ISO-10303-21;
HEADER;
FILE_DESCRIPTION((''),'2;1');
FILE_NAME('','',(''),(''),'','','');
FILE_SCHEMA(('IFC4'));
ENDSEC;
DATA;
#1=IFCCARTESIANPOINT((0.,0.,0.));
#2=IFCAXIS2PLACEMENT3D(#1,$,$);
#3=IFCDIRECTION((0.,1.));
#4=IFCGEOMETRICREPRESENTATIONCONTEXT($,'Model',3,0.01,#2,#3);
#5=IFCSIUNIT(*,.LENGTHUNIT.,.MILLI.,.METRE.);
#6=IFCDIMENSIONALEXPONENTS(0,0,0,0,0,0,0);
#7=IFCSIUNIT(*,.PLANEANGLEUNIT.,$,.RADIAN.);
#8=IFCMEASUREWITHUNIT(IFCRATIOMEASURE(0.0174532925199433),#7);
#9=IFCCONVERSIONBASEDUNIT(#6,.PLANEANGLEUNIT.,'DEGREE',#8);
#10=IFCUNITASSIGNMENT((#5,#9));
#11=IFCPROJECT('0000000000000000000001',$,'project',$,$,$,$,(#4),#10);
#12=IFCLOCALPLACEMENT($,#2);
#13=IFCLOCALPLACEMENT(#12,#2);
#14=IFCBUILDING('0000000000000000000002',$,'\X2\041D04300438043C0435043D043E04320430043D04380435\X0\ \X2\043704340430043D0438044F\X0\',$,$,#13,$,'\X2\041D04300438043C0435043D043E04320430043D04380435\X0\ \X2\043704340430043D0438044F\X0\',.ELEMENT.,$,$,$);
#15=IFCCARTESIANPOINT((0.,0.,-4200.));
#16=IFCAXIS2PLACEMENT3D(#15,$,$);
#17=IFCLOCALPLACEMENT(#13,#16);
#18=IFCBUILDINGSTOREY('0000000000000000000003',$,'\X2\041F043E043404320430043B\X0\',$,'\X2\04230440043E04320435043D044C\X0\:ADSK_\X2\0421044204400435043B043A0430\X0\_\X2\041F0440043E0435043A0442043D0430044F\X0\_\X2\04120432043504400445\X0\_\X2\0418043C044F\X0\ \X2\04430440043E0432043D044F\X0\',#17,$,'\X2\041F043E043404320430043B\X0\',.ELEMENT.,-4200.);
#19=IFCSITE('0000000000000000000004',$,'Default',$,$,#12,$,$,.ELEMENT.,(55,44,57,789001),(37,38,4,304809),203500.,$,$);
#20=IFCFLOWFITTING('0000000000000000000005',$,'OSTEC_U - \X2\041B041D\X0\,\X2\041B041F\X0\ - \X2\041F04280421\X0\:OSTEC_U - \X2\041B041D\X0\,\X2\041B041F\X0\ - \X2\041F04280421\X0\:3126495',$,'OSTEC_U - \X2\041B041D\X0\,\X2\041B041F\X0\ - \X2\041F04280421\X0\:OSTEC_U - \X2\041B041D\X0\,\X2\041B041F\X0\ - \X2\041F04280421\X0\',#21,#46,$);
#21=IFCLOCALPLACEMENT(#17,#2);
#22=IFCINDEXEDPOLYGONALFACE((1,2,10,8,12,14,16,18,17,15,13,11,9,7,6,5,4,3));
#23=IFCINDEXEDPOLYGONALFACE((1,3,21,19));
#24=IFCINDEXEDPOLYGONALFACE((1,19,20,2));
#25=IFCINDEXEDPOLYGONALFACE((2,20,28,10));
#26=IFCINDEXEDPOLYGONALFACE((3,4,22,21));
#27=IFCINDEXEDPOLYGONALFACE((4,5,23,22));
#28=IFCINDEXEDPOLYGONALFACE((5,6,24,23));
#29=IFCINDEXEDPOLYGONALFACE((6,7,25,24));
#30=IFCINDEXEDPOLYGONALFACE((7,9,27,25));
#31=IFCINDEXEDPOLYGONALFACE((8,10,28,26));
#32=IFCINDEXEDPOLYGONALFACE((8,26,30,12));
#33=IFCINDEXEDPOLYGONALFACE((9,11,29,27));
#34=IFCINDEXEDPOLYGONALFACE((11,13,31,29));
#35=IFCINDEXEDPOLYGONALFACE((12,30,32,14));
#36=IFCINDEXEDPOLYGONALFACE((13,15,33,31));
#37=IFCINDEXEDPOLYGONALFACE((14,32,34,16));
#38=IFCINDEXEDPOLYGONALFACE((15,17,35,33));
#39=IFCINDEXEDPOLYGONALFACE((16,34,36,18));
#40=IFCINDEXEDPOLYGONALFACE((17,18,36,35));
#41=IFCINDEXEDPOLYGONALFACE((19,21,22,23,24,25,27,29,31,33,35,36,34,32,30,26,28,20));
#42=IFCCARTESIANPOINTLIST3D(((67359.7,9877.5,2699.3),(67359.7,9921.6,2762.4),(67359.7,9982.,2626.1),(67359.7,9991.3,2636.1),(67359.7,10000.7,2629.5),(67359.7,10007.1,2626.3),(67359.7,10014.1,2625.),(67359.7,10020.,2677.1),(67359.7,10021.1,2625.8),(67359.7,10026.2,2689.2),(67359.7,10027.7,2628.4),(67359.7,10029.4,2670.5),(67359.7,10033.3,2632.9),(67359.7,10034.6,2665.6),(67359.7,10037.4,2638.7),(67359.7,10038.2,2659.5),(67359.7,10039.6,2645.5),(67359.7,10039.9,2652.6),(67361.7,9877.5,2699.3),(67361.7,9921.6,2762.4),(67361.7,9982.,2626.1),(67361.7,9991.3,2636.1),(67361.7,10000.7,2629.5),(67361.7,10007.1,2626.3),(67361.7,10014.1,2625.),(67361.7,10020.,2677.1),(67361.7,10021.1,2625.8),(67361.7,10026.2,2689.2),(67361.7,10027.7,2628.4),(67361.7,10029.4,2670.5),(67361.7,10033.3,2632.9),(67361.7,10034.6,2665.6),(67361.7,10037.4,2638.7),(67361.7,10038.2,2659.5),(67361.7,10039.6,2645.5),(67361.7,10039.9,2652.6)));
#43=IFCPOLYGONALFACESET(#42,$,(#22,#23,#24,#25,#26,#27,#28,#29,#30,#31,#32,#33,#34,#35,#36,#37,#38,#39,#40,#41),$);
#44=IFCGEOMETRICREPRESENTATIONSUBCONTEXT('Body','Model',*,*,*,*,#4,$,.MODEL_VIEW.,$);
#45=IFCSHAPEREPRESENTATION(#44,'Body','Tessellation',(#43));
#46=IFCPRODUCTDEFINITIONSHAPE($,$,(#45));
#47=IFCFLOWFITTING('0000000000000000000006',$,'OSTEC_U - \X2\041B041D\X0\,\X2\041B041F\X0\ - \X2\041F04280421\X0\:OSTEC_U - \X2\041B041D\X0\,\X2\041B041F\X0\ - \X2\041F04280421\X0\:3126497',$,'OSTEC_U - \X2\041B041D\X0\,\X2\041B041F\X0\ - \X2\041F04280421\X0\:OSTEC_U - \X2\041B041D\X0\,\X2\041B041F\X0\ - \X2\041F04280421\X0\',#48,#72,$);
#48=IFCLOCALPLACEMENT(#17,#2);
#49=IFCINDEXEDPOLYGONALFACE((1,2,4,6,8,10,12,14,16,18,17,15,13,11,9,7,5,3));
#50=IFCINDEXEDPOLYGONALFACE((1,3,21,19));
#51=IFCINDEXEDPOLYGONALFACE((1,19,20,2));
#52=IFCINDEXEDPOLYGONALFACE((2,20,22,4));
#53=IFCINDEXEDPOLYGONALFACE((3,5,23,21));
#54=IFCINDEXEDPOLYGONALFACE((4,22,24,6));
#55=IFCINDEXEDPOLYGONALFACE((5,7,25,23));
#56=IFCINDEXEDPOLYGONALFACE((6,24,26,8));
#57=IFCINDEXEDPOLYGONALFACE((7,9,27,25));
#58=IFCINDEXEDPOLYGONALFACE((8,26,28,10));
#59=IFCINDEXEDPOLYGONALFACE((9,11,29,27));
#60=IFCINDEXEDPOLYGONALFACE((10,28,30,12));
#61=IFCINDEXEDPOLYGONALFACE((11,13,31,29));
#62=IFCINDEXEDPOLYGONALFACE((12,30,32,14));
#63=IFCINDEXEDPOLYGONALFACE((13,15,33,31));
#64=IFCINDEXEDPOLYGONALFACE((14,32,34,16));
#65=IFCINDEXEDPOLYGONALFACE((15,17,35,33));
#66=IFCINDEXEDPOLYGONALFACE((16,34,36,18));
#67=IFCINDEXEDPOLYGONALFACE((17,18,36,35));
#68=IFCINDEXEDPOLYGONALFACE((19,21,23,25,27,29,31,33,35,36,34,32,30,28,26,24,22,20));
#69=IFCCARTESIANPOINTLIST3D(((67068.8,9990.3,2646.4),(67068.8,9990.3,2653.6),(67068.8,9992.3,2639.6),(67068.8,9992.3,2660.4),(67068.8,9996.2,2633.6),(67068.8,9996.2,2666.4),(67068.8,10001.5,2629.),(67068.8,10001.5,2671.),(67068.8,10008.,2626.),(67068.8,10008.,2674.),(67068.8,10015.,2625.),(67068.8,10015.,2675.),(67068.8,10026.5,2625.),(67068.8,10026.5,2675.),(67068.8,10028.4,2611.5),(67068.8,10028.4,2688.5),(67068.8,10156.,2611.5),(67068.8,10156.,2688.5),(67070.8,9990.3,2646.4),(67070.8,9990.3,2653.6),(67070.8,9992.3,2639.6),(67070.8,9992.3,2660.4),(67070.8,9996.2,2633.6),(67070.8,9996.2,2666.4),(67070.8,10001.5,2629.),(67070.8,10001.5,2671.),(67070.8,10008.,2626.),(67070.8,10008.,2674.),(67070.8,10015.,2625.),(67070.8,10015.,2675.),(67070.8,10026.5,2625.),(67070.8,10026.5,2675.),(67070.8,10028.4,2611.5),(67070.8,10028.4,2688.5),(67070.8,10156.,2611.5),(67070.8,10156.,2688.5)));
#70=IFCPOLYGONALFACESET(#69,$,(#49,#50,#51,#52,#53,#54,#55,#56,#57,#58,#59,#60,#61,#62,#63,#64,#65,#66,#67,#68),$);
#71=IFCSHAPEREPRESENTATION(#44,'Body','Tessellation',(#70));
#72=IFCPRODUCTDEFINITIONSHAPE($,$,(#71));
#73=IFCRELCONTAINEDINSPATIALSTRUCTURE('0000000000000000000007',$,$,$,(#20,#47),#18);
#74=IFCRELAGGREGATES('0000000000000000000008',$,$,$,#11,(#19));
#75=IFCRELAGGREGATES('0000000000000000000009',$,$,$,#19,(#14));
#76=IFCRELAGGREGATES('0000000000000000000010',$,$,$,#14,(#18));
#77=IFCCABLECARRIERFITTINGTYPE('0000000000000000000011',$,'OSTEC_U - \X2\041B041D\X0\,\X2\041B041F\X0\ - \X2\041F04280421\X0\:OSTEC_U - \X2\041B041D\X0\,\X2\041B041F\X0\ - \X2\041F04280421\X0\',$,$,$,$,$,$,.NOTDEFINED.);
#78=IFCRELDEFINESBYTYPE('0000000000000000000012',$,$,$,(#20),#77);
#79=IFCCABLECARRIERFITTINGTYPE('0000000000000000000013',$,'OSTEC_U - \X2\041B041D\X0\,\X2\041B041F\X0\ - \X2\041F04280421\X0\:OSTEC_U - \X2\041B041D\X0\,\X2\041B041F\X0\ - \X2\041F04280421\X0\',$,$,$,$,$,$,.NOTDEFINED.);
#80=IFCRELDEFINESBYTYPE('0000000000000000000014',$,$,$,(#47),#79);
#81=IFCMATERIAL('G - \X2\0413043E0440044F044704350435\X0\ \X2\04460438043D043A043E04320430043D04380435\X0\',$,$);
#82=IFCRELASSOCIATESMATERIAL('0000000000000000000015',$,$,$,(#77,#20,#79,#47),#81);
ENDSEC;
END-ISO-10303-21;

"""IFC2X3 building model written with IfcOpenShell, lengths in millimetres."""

from ifc_helpers import new_model, entity, si_unit, converted_unit, direction, frame, frame_2d, origin, place, context, subcontext, project, spatial, polyline, circle_curve, parameter, trimmed, segment, composite_curve, outline, extrude, source, transform, mapped, material, type_object, type_shapes, element, save


model = new_model("IFC2X3")

# Units and contexts
model_context = context("Model", 3, precision=0.01, world=origin(), true_north=direction((0.0, 1.0)))
body_context = subcontext(model_context, "Body", "Model", "MODEL_VIEW")
ifc_project = project(units=[si_unit("LENGTHUNIT", "METRE", prefix="MILLI"), converted_unit("PLANEANGLEUNIT", "DEGREE", entity("IfcRatioMeasure", 0.0174532925199433), si_unit("PLANEANGLEUNIT", "RADIAN"), dimensions=[0, 0, 0, 0, 0, 0, 0])], contexts=[model_context])

# Site, building, storey
site_placement = place(None, origin())
site = spatial("IfcSite", under=ifc_project, at=site_placement, Name="Default", CompositionType="ELEMENT", RefLatitude=(55, 44, 57, 789001), RefLongitude=(37, 38, 4, 304809), RefElevation=203500.0)
building_placement = place(site_placement, origin())
building = spatial("IfcBuilding", under=site, at=building_placement, Name="Наименование здания", LongName="Наименование здания", CompositionType="ELEMENT")
storey_placement = place(building_placement, frame((0.0, 0.0, -4200.0)))
storey = spatial("IfcBuildingStorey", under=building, at=storey_placement, Name="Подвал", ObjectType="Уровень:ADSK_Стрелка_Проектная_Вверх_Имя уровня", LongName="Подвал", CompositionType="ELEMENT", Elevation=-4200.0)

# Flow fittings
ifc_material = material(Name="G - Горячее цинкование")
cable_carrier_fitting_type_1 = type_object("IfcCableCarrierFittingType", Name="OSTEC_U - ЛН,ЛП - ПШС:OSTEC_U - ЛН,ЛП - ПШС", PredefinedType="NOTDEFINED", material=ifc_material)
shared_shape_1 = source(origin(), body_context, "Body", "SweptSolid", [
    extrude(outline(composite_curve([segment(trimmed(circle_curve(frame_2d((-41.5, 0.0), x_axis=(1.0, 0.0)), 25.0), [parameter(90.0)], [parameter(270.0)], True, "PARAMETER"), True, "CONTINUOUS"), segment(polyline([(-41.5, -25.0), (-30.0, -25.0)]), True, "CONTINUOUS"), segment(polyline([(-30.0, -25.0), (-28.1, -38.5)]), True, "CONTINUOUS"), segment(polyline([(-28.1, -38.5), (99.5, -38.5)]), True, "CONTINUOUS"), segment(polyline([(99.5, -38.5), (99.5, 38.5)]), True, "CONTINUOUS"), segment(polyline([(99.5, 38.5), (-28.1, 38.5)]), True, "CONTINUOUS"), segment(polyline([(-28.1, 38.5), (-30.0, 25.0)]), True, "CONTINUOUS"), segment(polyline([(-30.0, 25.0), (-41.5, 25.0)]), True, "CONTINUOUS")], self_intersect=False)), frame((41.5, 0.0, 0.0)), (0.0, 0.0, 1.0), 2.0),
])
type_shapes(cable_carrier_fitting_type_1, [shared_shape_1])
flow_fitting_1_placement = place(storey_placement, frame((67359.7, 10015.0, 2650.0), z_axis=(1.0, 0.0, 0.0), x_axis=(0.0, -0.819152, 0.573576)))
element("IfcFlowFitting", 1, at=flow_fitting_1_placement, inside=storey, type_object=cable_carrier_fitting_type_1, material=ifc_material, Name="OSTEC_U - ЛН,ЛП - ПШС:OSTEC_U - ЛН,ЛП - ПШС:3126495", ObjectType="OSTEC_U - ЛН,ЛП - ПШС:OSTEC_U - ЛН,ЛП - ПШС", context=body_context, shape_type="MappedRepresentation", body=[
    mapped(shared_shape_1, transform((0.0, 0.0, 0.0), scale=1.0)),
])
cable_carrier_fitting_type_2 = type_object("IfcCableCarrierFittingType", Name="OSTEC_U - ЛН,ЛП - ПШС:OSTEC_U - ЛН,ЛП - ПШС", PredefinedType="NOTDEFINED", material=ifc_material)
type_shapes(cable_carrier_fitting_type_2, [shared_shape_1])
flow_fitting_2_placement = place(storey_placement, frame((67070.8, 10015.0, 2650.0), z_axis=(-1.0, 0.0, 0.0), x_axis=(0.0, 1.0, 0.0)))
element("IfcFlowFitting", 2, at=flow_fitting_2_placement, inside=storey, type_object=cable_carrier_fitting_type_2, material=ifc_material, Name="OSTEC_U - ЛН,ЛП - ПШС:OSTEC_U - ЛН,ЛП - ПШС:3126497", ObjectType="OSTEC_U - ЛН,ЛП - ПШС:OSTEC_U - ЛН,ЛП - ПШС", context=body_context, shape_type="MappedRepresentation", body=[
    mapped(shared_shape_1, transform((0.0, 0.0, 0.0), scale=1.0)),
])

save(model, "model.ifc")
